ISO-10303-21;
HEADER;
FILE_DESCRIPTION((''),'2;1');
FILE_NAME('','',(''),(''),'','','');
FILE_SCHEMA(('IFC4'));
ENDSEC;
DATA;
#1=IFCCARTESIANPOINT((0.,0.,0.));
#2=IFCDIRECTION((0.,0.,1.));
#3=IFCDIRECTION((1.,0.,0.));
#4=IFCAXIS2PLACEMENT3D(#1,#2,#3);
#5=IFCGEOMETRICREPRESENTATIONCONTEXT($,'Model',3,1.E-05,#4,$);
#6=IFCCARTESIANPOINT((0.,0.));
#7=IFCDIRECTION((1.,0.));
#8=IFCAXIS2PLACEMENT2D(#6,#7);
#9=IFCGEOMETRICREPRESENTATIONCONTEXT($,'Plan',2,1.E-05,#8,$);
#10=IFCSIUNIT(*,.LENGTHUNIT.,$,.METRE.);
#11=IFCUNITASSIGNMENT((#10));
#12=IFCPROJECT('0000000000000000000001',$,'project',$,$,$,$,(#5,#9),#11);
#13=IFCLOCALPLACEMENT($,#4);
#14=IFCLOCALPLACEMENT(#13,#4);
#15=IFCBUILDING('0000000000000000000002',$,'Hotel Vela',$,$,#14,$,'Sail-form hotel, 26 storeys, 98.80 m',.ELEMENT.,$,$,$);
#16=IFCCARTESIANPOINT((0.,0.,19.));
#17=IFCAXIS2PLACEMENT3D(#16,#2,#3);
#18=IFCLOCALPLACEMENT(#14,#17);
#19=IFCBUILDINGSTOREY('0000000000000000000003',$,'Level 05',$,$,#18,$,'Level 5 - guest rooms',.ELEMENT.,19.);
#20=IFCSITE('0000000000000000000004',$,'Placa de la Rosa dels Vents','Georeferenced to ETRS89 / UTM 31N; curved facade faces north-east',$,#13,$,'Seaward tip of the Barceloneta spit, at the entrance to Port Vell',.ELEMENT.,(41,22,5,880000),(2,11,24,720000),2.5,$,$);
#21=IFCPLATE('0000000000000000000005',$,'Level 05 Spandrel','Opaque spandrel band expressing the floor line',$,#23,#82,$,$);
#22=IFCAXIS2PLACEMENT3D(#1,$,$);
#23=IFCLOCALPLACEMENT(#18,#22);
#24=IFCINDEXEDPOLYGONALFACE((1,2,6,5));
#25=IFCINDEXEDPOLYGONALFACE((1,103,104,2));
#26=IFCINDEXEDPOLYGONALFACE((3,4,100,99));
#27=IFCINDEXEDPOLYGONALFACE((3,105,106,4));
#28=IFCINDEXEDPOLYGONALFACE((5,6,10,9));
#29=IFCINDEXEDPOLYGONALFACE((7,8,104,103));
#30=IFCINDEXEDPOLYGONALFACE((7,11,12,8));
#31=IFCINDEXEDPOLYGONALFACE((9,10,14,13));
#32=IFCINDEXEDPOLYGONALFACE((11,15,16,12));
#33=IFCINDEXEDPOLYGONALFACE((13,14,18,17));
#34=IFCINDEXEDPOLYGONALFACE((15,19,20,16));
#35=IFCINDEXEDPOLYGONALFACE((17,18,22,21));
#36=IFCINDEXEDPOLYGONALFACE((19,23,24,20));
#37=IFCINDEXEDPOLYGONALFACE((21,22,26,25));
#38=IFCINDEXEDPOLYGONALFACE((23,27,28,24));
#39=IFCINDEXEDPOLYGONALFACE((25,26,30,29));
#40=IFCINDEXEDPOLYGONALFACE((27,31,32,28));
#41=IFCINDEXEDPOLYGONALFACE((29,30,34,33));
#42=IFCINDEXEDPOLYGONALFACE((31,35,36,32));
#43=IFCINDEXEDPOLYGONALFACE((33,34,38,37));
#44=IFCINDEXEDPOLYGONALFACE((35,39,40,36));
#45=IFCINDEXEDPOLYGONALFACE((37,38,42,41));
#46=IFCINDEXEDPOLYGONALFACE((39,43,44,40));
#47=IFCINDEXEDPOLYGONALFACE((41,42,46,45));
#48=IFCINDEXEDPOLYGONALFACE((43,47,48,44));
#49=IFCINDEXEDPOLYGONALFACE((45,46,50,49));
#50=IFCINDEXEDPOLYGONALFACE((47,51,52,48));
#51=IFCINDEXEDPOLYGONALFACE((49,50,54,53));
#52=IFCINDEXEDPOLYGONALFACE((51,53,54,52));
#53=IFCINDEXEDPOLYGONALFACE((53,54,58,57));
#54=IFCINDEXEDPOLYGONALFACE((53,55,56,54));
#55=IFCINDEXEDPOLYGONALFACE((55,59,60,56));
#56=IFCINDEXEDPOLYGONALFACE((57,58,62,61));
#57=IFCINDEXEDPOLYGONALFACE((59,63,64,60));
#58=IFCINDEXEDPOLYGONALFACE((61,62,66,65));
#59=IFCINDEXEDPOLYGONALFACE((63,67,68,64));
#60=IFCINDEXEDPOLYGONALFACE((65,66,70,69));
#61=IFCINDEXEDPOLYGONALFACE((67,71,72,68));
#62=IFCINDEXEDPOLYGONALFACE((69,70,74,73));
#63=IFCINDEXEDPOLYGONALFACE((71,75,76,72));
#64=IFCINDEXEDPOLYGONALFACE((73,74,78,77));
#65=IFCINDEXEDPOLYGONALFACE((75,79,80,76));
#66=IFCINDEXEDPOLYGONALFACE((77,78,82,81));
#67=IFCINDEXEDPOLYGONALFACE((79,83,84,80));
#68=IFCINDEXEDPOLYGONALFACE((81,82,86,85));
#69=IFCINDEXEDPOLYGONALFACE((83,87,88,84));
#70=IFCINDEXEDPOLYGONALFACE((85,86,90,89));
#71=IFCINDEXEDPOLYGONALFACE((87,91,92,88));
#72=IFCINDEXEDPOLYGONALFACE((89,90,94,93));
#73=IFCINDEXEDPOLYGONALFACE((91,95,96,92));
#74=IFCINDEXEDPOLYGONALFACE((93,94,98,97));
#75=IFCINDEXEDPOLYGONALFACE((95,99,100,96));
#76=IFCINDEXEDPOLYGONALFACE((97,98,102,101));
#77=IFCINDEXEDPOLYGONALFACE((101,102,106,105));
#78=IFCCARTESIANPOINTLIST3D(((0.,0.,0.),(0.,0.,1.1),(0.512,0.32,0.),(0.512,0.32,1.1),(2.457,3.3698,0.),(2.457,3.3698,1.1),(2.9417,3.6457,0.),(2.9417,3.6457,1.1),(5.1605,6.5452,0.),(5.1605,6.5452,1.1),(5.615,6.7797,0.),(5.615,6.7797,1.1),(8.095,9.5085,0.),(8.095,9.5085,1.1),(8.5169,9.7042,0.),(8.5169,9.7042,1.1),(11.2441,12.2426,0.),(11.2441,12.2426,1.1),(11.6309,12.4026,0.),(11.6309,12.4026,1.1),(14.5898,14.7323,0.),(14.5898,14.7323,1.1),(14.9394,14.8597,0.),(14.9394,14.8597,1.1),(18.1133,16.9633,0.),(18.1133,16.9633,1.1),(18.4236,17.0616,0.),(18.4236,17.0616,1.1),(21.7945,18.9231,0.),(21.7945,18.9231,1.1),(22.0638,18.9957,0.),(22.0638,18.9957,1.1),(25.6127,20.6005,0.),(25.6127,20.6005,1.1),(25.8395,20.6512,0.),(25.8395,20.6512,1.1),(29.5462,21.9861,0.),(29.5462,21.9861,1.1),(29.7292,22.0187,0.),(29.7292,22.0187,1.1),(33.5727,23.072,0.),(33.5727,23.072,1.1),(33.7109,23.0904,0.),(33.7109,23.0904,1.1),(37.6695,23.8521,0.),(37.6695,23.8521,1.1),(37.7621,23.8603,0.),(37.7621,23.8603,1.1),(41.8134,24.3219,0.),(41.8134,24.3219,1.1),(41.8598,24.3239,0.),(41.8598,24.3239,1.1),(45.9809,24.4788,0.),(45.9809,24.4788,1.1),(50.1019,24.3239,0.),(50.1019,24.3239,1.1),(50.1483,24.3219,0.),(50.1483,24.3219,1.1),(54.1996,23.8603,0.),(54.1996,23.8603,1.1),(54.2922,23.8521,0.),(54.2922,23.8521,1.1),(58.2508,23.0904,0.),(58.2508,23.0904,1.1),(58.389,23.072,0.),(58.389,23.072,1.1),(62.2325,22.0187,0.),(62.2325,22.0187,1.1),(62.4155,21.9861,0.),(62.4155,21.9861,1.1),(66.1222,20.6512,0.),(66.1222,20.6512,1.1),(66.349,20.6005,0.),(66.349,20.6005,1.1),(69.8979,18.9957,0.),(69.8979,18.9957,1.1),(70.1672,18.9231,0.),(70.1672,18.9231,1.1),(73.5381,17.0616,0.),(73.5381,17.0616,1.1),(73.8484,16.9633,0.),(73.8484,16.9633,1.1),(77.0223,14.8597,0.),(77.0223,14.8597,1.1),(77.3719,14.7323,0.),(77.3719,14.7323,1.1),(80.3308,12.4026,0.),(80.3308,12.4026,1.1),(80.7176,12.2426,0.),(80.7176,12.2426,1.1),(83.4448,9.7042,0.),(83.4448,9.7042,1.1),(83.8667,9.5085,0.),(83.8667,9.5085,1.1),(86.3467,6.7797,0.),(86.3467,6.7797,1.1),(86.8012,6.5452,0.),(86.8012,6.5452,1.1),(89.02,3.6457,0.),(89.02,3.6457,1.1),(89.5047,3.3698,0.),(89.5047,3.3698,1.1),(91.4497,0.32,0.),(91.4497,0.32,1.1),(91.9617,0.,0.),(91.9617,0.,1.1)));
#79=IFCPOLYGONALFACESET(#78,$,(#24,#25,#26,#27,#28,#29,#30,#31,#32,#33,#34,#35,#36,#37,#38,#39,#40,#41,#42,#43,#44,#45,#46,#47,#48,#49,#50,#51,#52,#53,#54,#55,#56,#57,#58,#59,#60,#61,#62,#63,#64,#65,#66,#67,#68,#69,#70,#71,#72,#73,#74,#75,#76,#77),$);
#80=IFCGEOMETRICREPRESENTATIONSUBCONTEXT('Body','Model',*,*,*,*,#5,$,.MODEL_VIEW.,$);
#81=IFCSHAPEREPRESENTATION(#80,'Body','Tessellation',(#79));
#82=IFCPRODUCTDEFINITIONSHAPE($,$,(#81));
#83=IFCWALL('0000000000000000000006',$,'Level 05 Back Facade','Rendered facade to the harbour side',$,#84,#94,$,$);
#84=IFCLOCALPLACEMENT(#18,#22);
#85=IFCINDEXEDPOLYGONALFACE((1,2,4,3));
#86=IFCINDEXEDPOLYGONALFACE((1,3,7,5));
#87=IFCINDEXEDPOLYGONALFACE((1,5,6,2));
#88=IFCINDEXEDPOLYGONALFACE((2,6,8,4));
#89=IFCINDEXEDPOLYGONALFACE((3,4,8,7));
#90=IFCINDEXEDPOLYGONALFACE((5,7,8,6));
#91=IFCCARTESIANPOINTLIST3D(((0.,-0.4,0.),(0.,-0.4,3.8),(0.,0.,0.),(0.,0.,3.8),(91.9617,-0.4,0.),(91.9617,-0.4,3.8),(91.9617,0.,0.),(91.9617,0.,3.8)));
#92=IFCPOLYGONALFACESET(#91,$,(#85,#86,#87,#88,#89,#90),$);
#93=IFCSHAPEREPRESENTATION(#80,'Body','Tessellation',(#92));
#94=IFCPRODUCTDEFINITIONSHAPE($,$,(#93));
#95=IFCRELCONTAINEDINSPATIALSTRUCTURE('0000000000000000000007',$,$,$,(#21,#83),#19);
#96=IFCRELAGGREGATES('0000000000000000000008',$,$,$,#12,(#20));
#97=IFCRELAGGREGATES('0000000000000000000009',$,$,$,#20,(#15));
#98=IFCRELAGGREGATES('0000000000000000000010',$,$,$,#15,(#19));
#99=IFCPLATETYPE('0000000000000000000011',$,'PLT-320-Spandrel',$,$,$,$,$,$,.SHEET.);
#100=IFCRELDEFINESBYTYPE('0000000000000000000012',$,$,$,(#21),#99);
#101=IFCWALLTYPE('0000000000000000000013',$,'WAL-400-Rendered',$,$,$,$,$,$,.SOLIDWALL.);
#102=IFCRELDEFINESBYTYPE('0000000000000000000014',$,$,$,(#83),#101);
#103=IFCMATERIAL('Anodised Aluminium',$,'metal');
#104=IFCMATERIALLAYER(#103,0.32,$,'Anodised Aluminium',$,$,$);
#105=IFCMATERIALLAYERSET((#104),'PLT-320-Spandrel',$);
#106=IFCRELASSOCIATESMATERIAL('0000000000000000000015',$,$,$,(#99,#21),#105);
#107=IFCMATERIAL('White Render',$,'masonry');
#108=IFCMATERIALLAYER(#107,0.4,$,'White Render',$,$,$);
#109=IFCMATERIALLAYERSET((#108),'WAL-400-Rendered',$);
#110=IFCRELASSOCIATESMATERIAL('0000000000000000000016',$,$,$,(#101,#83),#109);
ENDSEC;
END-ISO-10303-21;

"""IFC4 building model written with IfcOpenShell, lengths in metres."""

from ifc_helpers import new_model, si_unit, frame, origin_with_axes, origin_2d_with_axis, place, context, subcontext, project, spatial, line, indexed_curve, outline, extrude, material, layer, layer_set, layer_usage, type_object, element, save


model = new_model("IFC4")

# Units and contexts
model_context = context("Model", 3, precision=1e-05, world=origin_with_axes())
plan_context = context("Plan", 2, precision=1e-05, world=origin_2d_with_axis())
body_context = subcontext(model_context, "Body", "Model", "MODEL_VIEW")
ifc_project = project(units=[si_unit("LENGTHUNIT", "METRE")], contexts=[model_context, plan_context])

# Site, building, storey
site_placement = place(None, origin_with_axes())
site = spatial("IfcSite", under=ifc_project, at=site_placement, Name="Placa de la Rosa dels Vents", Description="Georeferenced to ETRS89 / UTM 31N; curved facade faces north-east", LongName="Seaward tip of the Barceloneta spit, at the entrance to Port Vell", CompositionType="ELEMENT", RefLatitude=(41, 22, 5, 880000), RefLongitude=(2, 11, 24, 720000), RefElevation=2.5)
building_placement = place(site_placement, origin_with_axes())
building = spatial("IfcBuilding", under=site, at=building_placement, Name="Hotel Vela", LongName="Sail-form hotel, 26 storeys, 98.80 m", CompositionType="ELEMENT")
storey_placement = place(building_placement, frame((0.0, 0.0, 19.0), z_axis=(0.0, 0.0, 1.0), x_axis=(1.0, 0.0, 0.0)))
storey = spatial("IfcBuildingStorey", under=building, at=storey_placement, Name="Level 05", LongName="Level 5 - guest rooms", CompositionType="ELEMENT", Elevation=19.0)

# Plate
ifc_material_1 = material(Name="Anodised Aluminium", Category="metal")
ifc_layer_1 = layer(ifc_material_1, 0.32, Name="Anodised Aluminium")
ifc_layer_set_1 = layer_set([ifc_layer_1], Name="PLT-320-Spandrel")
ifc_layer_usage_1 = layer_usage(ifc_layer_set_1, "AXIS2", "POSITIVE", 0.0)
plate_type_1 = type_object("IfcPlateType", Name="PLT-320-Spandrel", PredefinedType="SHEET", material=ifc_layer_set_1)
plate_1_placement = place(storey_placement, origin_with_axes())
element("IfcPlate", 1, at=plate_1_placement, inside=storey, type_object=plate_type_1, material=ifc_layer_usage_1, Name="Level 05 Spandrel", Description="Opaque spandrel band expressing the floor line", context=body_context, shape_type="SweptSolid", body=[
    extrude(outline(indexed_curve([(91.9617, 0.0), (89.5047, 3.3698), (86.8012, 6.5452), (83.8667, 9.5085), (80.7176, 12.2426), (77.3719, 14.7323), (73.8484, 16.9633), (70.1672, 18.9231), (66.349, 20.6005), (62.4155, 21.9861), (58.389, 23.072), (54.2922, 23.8521), (50.1483, 24.3219), (45.9809, 24.4788), (41.8134, 24.3219), (37.6695, 23.8521), (33.5727, 23.072), (29.5462, 21.9861), (25.6127, 20.6005), (21.7945, 18.9231), (18.1133, 16.9633), (14.5898, 14.7323), (11.2441, 12.2426), (8.095, 9.5085), (5.1605, 6.5452), (2.457, 3.3698), (0.0, 0.0), (91.4497, 0.32), (2.9417, 3.6457), (5.615, 6.7797), (8.5169, 9.7042), (11.6309, 12.4026), (14.9394, 14.8597), (18.4236, 17.0616), (22.0638, 18.9957), (25.8395, 20.6512), (29.7292, 22.0187), (33.7109, 23.0904), (37.7621, 23.8603), (41.8598, 24.3239), (45.9809, 24.4788), (50.1019, 24.3239), (54.1996, 23.8603), (58.2508, 23.0904), (62.2325, 22.0187), (66.1222, 20.6512), (69.8979, 18.9957), (73.5381, 17.0616), (77.0223, 14.8597), (80.3308, 12.4026), (83.4448, 9.7042), (86.3467, 6.7797), (89.02, 3.6457), (0.512, 0.32)], segments=[line(1, 2, 3, 4, 5, 6, 7, 8, 9, 10, 11, 12, 13, 14, 15, 16, 17, 18, 19, 20, 21, 22, 23, 24, 25, 26, 27, 28, 29, 30, 31, 32, 33, 34, 35, 36, 37, 38, 39, 40, 41, 42, 43, 44, 45, 46, 47, 48, 49, 50, 51, 52, 53, 54, 1)])), origin_with_axes(), (0.0, 0.0, 1.0), 1.1),
])

# Wall
ifc_material_2 = material(Name="White Render", Category="masonry")
ifc_layer_2 = layer(ifc_material_2, 0.4, Name="White Render")
ifc_layer_set_2 = layer_set([ifc_layer_2], Name="WAL-400-Rendered")
ifc_layer_usage_2 = layer_usage(ifc_layer_set_2, "AXIS2", "POSITIVE", 0.0)
wall_type = type_object("IfcWallType", Name="WAL-400-Rendered", PredefinedType="SOLIDWALL", material=ifc_layer_set_2)
wall_placement = place(storey_placement, frame((0.0, -0.4, 0.0), z_axis=(0.0, 0.0, 1.0), x_axis=(1.0, 0.0, 0.0)))
element("IfcWall", 2, at=wall_placement, inside=storey, type_object=wall_type, material=ifc_layer_usage_2, Name="Level 05 Back Facade", Description="Rendered facade to the harbour side", context=body_context, shape_type="SweptSolid", body=[
    extrude(outline(indexed_curve([(0.0, 0.0), (91.9617, 0.0), (91.9617, 0.4), (0.0, 0.4)], segments=[line(1, 2, 3, 4, 1)])), origin_with_axes(), (0.0, 0.0, 1.0), 3.8),
])

save(model, "model.ifc")
